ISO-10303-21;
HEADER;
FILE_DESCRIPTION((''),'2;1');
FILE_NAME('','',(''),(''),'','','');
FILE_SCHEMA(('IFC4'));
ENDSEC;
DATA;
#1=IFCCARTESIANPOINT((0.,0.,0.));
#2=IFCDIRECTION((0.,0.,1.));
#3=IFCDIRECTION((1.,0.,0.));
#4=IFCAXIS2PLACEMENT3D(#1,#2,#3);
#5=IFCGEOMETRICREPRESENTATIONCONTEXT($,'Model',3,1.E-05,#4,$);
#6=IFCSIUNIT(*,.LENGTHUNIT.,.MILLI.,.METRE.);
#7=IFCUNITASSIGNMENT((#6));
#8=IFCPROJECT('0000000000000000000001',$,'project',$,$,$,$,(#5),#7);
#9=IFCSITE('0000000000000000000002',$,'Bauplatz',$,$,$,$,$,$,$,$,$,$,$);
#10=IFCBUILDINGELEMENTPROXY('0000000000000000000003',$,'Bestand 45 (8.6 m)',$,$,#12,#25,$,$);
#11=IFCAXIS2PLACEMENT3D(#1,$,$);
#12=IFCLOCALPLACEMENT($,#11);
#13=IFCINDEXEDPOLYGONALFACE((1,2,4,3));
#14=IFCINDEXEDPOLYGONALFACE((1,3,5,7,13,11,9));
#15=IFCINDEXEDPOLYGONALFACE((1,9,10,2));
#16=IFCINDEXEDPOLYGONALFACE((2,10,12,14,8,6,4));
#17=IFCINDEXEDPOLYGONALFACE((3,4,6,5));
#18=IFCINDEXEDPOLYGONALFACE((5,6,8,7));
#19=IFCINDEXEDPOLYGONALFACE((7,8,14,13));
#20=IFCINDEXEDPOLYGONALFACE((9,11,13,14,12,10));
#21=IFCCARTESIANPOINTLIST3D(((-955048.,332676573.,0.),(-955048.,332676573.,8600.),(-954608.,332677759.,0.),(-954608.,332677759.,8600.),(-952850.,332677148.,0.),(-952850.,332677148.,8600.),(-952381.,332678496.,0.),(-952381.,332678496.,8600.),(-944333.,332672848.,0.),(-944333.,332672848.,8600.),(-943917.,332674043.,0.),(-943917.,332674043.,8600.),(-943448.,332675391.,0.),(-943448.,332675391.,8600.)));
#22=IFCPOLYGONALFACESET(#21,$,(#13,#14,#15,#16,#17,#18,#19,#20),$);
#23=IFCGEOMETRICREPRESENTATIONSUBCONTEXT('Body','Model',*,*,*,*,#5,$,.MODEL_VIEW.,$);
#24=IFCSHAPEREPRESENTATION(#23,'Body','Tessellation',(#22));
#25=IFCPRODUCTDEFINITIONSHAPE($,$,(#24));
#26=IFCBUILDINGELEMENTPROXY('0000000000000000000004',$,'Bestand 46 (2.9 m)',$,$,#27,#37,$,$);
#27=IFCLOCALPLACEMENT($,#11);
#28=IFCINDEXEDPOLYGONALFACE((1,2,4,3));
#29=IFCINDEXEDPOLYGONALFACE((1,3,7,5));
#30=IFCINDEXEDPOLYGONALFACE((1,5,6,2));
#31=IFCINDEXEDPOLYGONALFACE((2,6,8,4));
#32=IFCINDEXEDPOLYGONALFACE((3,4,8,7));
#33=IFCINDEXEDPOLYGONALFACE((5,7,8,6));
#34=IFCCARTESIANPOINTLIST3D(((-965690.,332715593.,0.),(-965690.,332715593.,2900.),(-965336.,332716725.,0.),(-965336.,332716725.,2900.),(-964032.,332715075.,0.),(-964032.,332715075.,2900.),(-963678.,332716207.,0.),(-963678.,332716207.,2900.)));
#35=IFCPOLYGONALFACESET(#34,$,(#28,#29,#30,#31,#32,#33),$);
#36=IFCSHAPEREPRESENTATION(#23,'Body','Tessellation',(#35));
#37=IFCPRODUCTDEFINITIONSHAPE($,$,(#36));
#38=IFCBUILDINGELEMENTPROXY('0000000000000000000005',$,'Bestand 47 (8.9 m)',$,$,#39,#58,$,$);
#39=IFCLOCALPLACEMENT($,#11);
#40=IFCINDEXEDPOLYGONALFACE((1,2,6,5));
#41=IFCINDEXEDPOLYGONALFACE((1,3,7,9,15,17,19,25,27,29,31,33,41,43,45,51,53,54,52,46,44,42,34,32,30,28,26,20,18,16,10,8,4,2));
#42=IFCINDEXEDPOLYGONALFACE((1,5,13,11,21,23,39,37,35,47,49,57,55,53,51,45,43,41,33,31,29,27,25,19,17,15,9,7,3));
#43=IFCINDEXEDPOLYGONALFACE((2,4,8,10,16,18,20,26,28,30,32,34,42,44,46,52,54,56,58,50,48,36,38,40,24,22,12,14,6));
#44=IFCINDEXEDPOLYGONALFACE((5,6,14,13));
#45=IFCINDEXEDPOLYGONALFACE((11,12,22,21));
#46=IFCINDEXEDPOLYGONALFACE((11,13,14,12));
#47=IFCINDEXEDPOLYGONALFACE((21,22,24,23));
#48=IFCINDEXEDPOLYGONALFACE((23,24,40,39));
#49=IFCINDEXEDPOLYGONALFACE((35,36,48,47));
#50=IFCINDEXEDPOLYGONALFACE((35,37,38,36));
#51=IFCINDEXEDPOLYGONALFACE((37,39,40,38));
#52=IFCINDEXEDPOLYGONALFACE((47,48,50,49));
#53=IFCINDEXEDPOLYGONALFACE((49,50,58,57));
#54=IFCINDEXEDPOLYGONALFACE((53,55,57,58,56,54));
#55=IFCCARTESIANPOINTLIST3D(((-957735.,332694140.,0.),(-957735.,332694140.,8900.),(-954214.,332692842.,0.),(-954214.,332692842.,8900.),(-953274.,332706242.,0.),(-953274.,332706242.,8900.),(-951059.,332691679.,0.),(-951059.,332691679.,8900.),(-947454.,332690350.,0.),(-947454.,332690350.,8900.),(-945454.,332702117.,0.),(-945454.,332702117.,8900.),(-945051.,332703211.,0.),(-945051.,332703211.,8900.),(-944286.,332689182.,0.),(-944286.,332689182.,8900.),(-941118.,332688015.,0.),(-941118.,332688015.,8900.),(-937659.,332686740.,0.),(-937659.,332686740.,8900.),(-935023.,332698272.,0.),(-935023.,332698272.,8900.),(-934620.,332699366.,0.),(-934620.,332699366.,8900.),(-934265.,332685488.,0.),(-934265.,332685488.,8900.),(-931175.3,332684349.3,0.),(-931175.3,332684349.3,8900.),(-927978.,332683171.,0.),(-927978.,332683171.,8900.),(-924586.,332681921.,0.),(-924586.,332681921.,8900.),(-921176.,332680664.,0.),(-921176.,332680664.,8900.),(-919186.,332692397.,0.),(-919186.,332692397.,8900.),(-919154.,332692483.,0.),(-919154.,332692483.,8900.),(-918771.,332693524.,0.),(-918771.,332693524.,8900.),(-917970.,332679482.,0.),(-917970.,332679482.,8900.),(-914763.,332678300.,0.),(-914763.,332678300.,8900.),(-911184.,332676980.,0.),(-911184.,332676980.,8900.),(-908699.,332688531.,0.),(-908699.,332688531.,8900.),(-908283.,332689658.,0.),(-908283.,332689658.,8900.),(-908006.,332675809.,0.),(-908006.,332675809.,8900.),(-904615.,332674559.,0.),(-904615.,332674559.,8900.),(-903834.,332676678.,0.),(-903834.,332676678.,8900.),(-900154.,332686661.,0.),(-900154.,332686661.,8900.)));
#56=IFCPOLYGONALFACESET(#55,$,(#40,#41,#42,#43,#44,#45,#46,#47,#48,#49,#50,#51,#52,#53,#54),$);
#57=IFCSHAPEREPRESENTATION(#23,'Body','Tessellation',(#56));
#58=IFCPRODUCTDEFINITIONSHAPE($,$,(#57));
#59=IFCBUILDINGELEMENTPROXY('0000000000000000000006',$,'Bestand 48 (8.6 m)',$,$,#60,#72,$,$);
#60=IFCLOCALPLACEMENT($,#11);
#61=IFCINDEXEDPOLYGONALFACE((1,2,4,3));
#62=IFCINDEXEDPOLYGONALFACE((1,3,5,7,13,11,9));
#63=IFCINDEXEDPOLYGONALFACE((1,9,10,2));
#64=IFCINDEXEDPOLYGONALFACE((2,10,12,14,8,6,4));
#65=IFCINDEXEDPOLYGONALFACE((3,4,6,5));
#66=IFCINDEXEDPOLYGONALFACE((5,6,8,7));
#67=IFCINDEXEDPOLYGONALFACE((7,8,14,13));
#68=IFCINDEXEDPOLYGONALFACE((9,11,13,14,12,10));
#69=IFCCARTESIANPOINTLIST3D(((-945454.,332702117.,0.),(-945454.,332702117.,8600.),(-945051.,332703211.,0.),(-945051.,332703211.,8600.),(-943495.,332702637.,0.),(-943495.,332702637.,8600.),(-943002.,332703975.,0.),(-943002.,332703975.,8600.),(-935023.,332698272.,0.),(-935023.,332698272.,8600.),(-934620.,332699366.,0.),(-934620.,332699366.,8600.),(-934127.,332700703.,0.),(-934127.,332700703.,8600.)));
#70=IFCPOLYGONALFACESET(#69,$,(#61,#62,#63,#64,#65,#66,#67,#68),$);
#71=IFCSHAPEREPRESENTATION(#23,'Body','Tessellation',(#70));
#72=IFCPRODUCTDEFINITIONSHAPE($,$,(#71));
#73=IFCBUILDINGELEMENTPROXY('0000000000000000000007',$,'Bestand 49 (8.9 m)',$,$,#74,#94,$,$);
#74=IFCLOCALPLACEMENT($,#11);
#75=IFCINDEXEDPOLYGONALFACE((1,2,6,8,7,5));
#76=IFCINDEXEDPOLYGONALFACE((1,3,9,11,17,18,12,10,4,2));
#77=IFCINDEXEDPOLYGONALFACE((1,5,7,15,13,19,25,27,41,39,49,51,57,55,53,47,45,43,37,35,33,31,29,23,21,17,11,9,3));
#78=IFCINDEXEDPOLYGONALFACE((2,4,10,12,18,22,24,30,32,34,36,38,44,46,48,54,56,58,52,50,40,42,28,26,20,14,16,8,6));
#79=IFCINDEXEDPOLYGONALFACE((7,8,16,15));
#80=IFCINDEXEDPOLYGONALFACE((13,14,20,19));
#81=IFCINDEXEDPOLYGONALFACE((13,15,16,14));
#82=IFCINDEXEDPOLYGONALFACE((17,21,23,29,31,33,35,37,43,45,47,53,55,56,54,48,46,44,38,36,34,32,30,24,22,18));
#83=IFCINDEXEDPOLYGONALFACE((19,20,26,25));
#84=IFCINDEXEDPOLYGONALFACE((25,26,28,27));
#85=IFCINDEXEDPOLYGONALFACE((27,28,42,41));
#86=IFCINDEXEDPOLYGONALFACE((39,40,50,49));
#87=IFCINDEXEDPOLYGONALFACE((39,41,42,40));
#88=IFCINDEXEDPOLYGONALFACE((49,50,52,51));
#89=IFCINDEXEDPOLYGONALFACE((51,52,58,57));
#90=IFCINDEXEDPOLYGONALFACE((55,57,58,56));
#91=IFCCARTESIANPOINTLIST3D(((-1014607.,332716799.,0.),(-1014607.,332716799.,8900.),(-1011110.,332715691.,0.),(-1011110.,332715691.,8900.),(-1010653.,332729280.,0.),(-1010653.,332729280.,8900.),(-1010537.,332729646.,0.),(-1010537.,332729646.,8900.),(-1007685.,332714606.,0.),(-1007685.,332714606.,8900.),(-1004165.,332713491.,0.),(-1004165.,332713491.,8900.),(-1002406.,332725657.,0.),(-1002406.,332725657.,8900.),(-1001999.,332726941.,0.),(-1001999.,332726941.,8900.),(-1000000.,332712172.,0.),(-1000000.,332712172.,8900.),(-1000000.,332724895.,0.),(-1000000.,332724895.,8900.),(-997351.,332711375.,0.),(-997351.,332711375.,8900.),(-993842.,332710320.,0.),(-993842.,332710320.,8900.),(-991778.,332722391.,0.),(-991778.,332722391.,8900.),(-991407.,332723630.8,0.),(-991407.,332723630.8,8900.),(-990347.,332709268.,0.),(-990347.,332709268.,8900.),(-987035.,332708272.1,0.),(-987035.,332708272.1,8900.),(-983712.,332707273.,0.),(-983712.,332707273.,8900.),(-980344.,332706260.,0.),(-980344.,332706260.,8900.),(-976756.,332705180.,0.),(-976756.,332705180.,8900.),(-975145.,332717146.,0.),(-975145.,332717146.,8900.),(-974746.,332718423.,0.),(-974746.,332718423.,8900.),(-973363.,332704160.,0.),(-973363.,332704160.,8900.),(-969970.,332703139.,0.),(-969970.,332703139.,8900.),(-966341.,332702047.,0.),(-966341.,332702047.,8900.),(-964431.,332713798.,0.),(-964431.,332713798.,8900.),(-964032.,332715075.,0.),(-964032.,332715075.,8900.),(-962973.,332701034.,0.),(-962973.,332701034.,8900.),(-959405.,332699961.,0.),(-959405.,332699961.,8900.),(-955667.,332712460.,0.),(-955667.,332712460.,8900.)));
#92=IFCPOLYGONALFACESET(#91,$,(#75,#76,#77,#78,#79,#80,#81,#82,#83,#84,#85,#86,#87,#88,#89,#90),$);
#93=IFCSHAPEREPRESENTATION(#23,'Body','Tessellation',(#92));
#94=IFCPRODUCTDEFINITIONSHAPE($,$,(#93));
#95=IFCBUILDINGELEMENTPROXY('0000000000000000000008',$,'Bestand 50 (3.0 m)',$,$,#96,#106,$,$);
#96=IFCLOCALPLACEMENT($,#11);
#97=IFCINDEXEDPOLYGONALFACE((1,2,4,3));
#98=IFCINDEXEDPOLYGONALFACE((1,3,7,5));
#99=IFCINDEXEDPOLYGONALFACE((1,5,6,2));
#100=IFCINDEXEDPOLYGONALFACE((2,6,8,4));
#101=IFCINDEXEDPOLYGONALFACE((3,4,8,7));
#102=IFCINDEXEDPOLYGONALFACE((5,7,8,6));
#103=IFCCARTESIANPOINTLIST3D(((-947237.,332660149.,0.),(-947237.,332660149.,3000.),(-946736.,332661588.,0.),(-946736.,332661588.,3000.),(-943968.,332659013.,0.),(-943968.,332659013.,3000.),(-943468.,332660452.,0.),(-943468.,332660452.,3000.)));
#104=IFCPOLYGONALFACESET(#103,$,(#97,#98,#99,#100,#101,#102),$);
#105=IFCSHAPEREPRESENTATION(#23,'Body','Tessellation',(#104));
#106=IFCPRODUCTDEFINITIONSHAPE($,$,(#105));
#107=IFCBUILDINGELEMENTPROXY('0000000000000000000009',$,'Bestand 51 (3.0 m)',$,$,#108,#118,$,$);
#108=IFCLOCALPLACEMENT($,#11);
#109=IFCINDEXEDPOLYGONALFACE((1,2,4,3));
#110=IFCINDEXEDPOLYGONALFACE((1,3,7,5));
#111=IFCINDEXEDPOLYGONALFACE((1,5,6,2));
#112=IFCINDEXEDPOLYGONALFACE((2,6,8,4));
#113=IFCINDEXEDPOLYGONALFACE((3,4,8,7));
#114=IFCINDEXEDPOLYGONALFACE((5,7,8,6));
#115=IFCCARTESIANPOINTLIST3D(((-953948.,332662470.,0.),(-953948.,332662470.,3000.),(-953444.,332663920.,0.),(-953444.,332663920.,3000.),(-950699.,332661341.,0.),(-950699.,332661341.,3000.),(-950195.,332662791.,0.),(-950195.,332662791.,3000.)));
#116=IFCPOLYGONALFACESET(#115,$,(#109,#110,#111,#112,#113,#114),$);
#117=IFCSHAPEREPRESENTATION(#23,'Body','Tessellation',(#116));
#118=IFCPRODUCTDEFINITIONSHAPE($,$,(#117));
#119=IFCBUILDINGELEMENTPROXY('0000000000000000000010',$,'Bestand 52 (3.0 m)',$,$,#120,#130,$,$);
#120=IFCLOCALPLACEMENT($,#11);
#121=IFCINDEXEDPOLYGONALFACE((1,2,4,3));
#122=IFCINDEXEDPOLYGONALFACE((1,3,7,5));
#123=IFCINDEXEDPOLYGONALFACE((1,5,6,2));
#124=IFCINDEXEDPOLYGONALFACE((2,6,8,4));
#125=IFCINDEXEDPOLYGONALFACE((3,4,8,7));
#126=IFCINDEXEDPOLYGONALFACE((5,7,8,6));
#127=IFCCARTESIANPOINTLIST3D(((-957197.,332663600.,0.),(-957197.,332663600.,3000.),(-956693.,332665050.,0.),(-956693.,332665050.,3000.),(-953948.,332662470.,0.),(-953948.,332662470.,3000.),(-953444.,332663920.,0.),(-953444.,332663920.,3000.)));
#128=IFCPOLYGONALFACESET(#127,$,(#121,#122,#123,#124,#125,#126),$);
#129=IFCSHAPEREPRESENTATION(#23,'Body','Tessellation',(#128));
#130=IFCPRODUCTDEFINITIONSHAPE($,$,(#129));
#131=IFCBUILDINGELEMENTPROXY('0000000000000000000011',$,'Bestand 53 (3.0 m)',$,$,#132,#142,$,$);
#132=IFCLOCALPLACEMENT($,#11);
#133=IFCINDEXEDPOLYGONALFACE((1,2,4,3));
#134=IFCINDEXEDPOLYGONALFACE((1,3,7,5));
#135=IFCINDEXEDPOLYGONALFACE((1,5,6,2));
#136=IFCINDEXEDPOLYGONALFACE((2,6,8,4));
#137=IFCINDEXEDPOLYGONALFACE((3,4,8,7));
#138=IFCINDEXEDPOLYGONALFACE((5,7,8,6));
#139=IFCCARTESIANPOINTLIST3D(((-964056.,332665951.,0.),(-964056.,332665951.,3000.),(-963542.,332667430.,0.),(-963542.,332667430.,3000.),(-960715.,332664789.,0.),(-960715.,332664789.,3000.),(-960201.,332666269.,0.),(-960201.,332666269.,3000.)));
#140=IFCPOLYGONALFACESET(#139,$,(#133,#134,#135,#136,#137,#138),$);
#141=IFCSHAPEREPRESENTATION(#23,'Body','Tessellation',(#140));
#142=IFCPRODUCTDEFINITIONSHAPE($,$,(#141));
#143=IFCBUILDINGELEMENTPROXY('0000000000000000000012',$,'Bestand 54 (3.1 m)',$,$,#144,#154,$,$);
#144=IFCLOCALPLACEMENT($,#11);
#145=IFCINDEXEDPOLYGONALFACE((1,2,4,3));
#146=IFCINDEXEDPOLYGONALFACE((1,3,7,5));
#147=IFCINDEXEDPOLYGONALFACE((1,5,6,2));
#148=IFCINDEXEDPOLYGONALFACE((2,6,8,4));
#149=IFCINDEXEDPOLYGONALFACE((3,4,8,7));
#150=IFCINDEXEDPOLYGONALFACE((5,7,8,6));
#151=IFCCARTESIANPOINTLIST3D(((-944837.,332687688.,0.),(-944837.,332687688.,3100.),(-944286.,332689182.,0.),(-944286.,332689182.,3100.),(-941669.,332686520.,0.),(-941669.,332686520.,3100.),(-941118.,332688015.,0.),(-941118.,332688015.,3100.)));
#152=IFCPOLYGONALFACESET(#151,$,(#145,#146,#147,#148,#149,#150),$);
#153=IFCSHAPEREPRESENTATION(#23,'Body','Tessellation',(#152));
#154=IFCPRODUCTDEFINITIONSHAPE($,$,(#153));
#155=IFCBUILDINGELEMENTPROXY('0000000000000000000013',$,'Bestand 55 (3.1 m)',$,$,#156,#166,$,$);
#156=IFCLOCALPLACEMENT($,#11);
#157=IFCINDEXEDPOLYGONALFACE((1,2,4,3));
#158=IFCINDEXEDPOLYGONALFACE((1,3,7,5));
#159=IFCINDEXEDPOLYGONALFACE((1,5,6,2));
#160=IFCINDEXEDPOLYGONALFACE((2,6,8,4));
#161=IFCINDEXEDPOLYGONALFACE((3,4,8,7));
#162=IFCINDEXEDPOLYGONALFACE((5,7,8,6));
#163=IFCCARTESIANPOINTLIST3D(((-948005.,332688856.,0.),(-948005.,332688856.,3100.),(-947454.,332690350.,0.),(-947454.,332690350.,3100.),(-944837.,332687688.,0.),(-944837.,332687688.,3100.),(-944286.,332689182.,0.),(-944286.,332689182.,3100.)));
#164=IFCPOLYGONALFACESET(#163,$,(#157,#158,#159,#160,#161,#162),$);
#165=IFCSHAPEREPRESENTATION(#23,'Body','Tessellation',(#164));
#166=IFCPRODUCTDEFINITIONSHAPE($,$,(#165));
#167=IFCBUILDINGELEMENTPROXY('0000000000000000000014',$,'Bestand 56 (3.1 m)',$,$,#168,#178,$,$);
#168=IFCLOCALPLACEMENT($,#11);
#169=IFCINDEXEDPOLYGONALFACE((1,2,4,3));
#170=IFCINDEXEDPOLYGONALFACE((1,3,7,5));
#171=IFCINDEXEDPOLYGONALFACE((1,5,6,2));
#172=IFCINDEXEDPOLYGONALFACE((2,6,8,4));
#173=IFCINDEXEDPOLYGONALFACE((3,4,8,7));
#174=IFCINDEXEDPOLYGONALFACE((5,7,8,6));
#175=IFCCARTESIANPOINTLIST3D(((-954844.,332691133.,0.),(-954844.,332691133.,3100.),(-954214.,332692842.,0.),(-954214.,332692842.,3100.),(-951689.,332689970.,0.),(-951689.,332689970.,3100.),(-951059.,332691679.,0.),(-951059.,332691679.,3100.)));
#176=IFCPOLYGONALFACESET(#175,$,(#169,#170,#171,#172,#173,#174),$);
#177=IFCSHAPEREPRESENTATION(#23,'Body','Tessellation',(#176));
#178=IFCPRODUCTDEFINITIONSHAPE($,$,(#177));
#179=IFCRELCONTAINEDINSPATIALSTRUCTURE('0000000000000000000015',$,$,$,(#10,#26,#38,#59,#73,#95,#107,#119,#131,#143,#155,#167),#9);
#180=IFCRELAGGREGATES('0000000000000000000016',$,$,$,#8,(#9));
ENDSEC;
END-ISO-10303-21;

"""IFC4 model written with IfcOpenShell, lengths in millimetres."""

from ifc_helpers import new_model, si_unit, origin_with_axes, place, context, subcontext, project, spatial, indexed_curve, outline, extrude, element, save


model = new_model("IFC4")

# Units and contexts
model_context = context("Model", 3, precision=1e-05, world=origin_with_axes())
body_context = subcontext(model_context, "Body", "Model", "MODEL_VIEW")
ifc_project = project(units=[si_unit("LENGTHUNIT", "METRE", prefix="MILLI")], contexts=[model_context])

# Site
site = spatial("IfcSite", under=ifc_project, Name="Bauplatz")

# Building element proxies
proxy_1_placement = place(None, origin_with_axes())
element("IfcBuildingElementProxy", 1, at=proxy_1_placement, inside=site, Name="Bestand 45 (8.6 m)", context=body_context, shape_type="SweptSolid", body=[
    extrude(outline(indexed_curve([(-943448.0, 332675391.0), (-952381.0, 332678496.0), (-952850.0, 332677148.0), (-954608.0, 332677759.0), (-955048.0, 332676573.0), (-944333.0, 332672848.0), (-943917.0, 332674043.0)])), None, (0.0, 0.0, 1.0), 8600.0),
])
proxy_2_placement = place(None, origin_with_axes())
element("IfcBuildingElementProxy", 2, at=proxy_2_placement, inside=site, Name="Bestand 46 (2.9 m)", context=body_context, shape_type="SweptSolid", body=[
    extrude(outline(indexed_curve([(-963678.0, 332716207.0), (-965336.0, 332716725.0), (-965690.0, 332715593.0), (-964032.0, 332715075.0)])), None, (0.0, 0.0, 1.0), 2900.0),
])
proxy_3_placement = place(None, origin_with_axes())
element("IfcBuildingElementProxy", 3, at=proxy_3_placement, inside=site, Name="Bestand 47 (8.9 m)", context=body_context, shape_type="SweptSolid", body=[
    extrude(outline(indexed_curve([(-945051.0, 332703211.0), (-953274.0, 332706242.0), (-957735.0, 332694140.0), (-954214.0, 332692842.0), (-951059.0, 332691679.0), (-947454.0, 332690350.0), (-944286.0, 332689182.0), (-941118.0, 332688015.0), (-937659.0, 332686740.0), (-934265.0, 332685488.0), (-931175.3, 332684349.3), (-927978.0, 332683171.0), (-924586.0, 332681921.0), (-921176.0, 332680664.0), (-917970.0, 332679482.0), (-914763.0, 332678300.0), (-911184.0, 332676980.0), (-908006.0, 332675809.0), (-904615.0, 332674559.0), (-903834.0, 332676678.0), (-900154.0, 332686661.0), (-908283.0, 332689658.0), (-908699.0, 332688531.0), (-919186.0, 332692397.0), (-919154.0, 332692483.0), (-918771.0, 332693524.0), (-934620.0, 332699366.0), (-935023.0, 332698272.0), (-945454.0, 332702117.0)])), None, (0.0, 0.0, 1.0), 8900.0),
])
proxy_4_placement = place(None, origin_with_axes())
element("IfcBuildingElementProxy", 4, at=proxy_4_placement, inside=site, Name="Bestand 48 (8.6 m)", context=body_context, shape_type="SweptSolid", body=[
    extrude(outline(indexed_curve([(-934127.0, 332700703.0), (-943002.0, 332703975.0), (-943495.0, 332702637.0), (-945051.0, 332703211.0), (-945454.0, 332702117.0), (-935023.0, 332698272.0), (-934620.0, 332699366.0)])), None, (0.0, 0.0, 1.0), 8600.0),
])
proxy_5_placement = place(None, origin_with_axes())
element("IfcBuildingElementProxy", 5, at=proxy_5_placement, inside=site, Name="Bestand 49 (8.9 m)", context=body_context, shape_type="SweptSolid", body=[
    extrude(outline(indexed_curve([(-1001999.0, 332726941.0), (-1010537.0, 332729646.0), (-1010653.0, 332729280.0), (-1014607.0, 332716799.0), (-1011110.0, 332715691.0), (-1007685.0, 332714606.0), (-1004165.0, 332713491.0), (-1000000.0, 332712172.0), (-997351.0, 332711375.0), (-993842.0, 332710320.0), (-990347.0, 332709268.0), (-987035.0, 332708272.1), (-983712.0, 332707273.0), (-980344.0, 332706260.0), (-976756.0, 332705180.0), (-973363.0, 332704160.0), (-969970.0, 332703139.0), (-966341.0, 332702047.0), (-962973.0, 332701034.0), (-959405.0, 332699961.0), (-955667.0, 332712460.0), (-964032.0, 332715075.0), (-964431.0, 332713798.0), (-975145.0, 332717146.0), (-974746.0, 332718423.0), (-991407.0, 332723630.8), (-991778.0, 332722391.0), (-1000000.0, 332724895.0), (-1002406.0, 332725657.0)])), None, (0.0, 0.0, 1.0), 8900.0),
])
proxy_6_placement = place(None, origin_with_axes())
element("IfcBuildingElementProxy", 6, at=proxy_6_placement, inside=site, Name="Bestand 50 (3.0 m)", context=body_context, shape_type="SweptSolid", body=[
    extrude(outline(indexed_curve([(-943468.0, 332660452.0), (-946736.0, 332661588.0), (-947237.0, 332660149.0), (-943968.0, 332659013.0)])), None, (0.0, 0.0, 1.0), 3000.0),
])
proxy_7_placement = place(None, origin_with_axes())
element("IfcBuildingElementProxy", 7, at=proxy_7_placement, inside=site, Name="Bestand 51 (3.0 m)", context=body_context, shape_type="SweptSolid", body=[
    extrude(outline(indexed_curve([(-950195.0, 332662791.0), (-953444.0, 332663920.0), (-953948.0, 332662470.0), (-950699.0, 332661341.0)])), None, (0.0, 0.0, 1.0), 3000.0),
])
proxy_8_placement = place(None, origin_with_axes())
element("IfcBuildingElementProxy", 8, at=proxy_8_placement, inside=site, Name="Bestand 52 (3.0 m)", context=body_context, shape_type="SweptSolid", body=[
    extrude(outline(indexed_curve([(-953444.0, 332663920.0), (-956693.0, 332665050.0), (-957197.0, 332663600.0), (-953948.0, 332662470.0)])), None, (0.0, 0.0, 1.0), 3000.0),
])
proxy_9_placement = place(None, origin_with_axes())
element("IfcBuildingElementProxy", 9, at=proxy_9_placement, inside=site, Name="Bestand 53 (3.0 m)", context=body_context, shape_type="SweptSolid", body=[
    extrude(outline(indexed_curve([(-960201.0, 332666269.0), (-963542.0, 332667430.0), (-964056.0, 332665951.0), (-960715.0, 332664789.0)])), None, (0.0, 0.0, 1.0), 3000.0),
])
proxy_10_placement = place(None, origin_with_axes())
element("IfcBuildingElementProxy", 10, at=proxy_10_placement, inside=site, Name="Bestand 54 (3.1 m)", context=body_context, shape_type="SweptSolid", body=[
    extrude(outline(indexed_curve([(-941118.0, 332688015.0), (-944286.0, 332689182.0), (-944837.0, 332687688.0), (-941669.0, 332686520.0)])), None, (0.0, 0.0, 1.0), 3100.0),
])
proxy_11_placement = place(None, origin_with_axes())
element("IfcBuildingElementProxy", 11, at=proxy_11_placement, inside=site, Name="Bestand 55 (3.1 m)", context=body_context, shape_type="SweptSolid", body=[
    extrude(outline(indexed_curve([(-944286.0, 332689182.0), (-947454.0, 332690350.0), (-948005.0, 332688856.0), (-944837.0, 332687688.0)])), None, (0.0, 0.0, 1.0), 3100.0),
])
proxy_12_placement = place(None, origin_with_axes())
element("IfcBuildingElementProxy", 12, at=proxy_12_placement, inside=site, Name="Bestand 56 (3.1 m)", context=body_context, shape_type="SweptSolid", body=[
    extrude(outline(indexed_curve([(-951059.0, 332691679.0), (-954214.0, 332692842.0), (-954844.0, 332691133.0), (-951689.0, 332689970.0)])), None, (0.0, 0.0, 1.0), 3100.0),
])

save(model, "model.ifc")
